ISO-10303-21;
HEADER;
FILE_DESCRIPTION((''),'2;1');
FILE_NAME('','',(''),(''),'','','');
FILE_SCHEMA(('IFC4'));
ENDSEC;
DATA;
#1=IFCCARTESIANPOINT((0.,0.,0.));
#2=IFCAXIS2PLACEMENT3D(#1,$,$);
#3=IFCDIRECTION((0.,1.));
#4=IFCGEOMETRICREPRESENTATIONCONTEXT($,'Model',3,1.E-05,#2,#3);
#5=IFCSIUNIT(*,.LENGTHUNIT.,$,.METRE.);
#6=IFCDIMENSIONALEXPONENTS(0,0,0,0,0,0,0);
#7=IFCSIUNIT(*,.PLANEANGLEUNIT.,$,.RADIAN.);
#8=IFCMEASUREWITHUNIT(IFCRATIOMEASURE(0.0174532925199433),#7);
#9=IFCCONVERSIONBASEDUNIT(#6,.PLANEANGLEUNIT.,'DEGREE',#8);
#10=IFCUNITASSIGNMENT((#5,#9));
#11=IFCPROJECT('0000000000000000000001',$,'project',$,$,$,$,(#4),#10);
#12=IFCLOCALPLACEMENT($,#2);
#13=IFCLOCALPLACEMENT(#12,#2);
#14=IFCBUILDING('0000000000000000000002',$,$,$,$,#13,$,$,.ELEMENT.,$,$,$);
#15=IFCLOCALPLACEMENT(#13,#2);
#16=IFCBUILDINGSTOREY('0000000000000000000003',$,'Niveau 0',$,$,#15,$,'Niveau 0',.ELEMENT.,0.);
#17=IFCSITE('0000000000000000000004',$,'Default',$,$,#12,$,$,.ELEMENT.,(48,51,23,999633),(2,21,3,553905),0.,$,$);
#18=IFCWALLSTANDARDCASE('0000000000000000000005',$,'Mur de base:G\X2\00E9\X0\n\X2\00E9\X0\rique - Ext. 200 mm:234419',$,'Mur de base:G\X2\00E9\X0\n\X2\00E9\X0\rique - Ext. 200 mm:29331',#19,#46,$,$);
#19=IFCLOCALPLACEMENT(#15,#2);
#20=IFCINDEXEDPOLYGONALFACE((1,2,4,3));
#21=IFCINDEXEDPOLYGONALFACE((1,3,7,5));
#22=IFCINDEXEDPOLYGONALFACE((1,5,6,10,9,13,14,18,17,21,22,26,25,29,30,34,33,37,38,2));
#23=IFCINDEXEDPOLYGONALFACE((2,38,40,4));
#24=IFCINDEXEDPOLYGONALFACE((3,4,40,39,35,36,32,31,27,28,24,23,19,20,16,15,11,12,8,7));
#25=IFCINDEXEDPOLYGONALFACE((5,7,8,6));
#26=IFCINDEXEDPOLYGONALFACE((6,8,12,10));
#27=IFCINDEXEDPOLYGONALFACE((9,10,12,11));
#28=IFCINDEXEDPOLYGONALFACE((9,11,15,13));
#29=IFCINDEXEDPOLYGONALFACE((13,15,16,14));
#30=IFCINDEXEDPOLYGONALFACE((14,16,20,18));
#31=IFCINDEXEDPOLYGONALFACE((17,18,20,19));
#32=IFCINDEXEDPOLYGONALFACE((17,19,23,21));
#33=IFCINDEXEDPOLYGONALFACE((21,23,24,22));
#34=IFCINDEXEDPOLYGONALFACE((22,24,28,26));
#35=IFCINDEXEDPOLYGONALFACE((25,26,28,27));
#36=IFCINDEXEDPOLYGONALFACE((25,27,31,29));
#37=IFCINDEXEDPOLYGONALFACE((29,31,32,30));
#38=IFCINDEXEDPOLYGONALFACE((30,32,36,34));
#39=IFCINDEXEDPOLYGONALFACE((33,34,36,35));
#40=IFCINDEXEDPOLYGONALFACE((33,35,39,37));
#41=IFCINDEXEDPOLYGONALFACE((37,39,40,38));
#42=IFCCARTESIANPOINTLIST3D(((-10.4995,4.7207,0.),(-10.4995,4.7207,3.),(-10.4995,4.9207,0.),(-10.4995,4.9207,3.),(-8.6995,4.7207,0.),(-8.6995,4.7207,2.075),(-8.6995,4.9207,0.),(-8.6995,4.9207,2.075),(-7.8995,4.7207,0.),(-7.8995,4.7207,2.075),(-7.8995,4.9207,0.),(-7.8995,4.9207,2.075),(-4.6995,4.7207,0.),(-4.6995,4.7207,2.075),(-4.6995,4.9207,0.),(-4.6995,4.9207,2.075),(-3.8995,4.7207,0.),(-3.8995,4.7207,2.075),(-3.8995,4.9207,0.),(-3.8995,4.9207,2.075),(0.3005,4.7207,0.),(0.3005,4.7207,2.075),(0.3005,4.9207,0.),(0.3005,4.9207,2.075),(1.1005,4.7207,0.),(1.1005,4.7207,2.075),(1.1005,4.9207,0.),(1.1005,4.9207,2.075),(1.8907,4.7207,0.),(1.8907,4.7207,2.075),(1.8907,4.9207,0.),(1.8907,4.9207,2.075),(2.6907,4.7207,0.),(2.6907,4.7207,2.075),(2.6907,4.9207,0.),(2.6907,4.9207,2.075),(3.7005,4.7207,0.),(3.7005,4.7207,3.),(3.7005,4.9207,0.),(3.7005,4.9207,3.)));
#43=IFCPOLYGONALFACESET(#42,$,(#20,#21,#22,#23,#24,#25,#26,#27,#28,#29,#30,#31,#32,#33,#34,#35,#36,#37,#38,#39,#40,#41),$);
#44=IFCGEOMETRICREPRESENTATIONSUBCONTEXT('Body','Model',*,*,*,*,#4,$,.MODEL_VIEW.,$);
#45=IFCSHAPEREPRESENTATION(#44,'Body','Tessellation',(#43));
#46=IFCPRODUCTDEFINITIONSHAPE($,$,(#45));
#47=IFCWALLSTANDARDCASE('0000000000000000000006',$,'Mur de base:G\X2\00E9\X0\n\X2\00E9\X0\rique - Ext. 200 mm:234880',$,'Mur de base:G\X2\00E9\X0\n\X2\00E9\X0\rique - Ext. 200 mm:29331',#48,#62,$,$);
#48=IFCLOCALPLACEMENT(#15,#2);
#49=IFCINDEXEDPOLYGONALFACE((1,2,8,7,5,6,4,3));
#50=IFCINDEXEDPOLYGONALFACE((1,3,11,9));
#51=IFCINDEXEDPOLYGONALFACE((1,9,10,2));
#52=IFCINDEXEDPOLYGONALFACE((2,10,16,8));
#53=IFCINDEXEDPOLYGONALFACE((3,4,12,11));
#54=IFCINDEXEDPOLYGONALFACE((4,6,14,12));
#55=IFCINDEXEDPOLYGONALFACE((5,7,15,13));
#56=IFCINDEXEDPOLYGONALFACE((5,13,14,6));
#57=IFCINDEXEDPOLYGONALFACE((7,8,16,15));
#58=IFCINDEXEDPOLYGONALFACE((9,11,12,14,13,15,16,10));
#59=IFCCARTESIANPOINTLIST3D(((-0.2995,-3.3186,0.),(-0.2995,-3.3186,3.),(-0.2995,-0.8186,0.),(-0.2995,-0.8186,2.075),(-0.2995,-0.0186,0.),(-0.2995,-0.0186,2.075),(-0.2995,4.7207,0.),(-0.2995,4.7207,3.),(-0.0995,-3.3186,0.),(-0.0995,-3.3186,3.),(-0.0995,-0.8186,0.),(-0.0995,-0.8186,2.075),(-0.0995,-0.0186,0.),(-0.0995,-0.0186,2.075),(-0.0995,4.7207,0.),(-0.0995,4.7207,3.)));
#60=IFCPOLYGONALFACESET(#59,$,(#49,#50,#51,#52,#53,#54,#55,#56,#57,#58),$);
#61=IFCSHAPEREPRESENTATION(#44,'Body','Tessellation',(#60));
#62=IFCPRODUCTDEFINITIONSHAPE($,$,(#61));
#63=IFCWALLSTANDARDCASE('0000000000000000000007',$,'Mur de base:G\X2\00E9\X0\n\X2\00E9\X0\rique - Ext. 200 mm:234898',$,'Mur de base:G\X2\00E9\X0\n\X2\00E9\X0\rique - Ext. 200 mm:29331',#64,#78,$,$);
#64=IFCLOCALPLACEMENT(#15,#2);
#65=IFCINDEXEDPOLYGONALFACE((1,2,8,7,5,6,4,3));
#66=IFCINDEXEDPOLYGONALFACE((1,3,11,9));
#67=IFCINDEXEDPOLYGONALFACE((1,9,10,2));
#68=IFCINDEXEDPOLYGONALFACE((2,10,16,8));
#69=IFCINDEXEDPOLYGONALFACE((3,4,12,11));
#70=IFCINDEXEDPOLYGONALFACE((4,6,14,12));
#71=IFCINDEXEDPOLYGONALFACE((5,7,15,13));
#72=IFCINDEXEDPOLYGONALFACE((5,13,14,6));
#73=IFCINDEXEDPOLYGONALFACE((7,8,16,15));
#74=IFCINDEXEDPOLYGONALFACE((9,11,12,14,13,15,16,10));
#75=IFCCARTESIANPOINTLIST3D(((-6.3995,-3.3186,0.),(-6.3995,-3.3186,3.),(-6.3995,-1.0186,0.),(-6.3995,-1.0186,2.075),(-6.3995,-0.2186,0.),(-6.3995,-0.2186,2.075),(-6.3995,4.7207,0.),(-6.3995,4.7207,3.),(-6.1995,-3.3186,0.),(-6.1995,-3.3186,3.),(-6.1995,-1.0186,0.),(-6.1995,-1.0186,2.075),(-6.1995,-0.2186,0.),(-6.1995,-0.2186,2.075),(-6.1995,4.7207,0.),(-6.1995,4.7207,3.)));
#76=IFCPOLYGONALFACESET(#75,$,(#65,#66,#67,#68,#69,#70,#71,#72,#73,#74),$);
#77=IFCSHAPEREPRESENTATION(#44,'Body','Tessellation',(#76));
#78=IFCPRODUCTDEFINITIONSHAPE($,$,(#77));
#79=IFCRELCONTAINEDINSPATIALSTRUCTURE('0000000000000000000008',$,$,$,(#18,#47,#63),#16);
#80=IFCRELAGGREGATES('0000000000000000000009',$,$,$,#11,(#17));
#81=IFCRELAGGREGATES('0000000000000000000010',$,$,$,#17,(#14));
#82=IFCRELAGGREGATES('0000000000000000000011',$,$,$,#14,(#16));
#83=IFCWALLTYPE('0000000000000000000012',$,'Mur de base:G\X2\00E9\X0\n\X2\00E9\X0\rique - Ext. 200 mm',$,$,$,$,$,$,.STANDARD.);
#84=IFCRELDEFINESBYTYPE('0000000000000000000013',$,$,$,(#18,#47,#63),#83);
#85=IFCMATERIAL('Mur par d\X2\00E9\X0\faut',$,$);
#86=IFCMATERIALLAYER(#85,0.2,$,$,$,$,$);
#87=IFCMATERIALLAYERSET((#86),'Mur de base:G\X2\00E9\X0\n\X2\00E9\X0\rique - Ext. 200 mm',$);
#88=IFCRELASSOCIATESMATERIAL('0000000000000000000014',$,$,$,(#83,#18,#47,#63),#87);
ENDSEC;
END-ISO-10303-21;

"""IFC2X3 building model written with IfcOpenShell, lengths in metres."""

from ifc_helpers import new_model, entity, si_unit, converted_unit, direction, frame, frame_2d, origin, place, context, subcontext, project, spatial, rectangle, extrude, material, layer, layer_set, layer_usage, type_object, element, save


model = new_model("IFC2X3")

# Units and contexts
model_context = context("Model", 3, precision=1e-05, world=origin(), true_north=direction((0.0, 1.0)))
body_context = subcontext(model_context, "Body", "Model", "MODEL_VIEW")
ifc_project = project(units=[si_unit("LENGTHUNIT", "METRE"), converted_unit("PLANEANGLEUNIT", "DEGREE", entity("IfcRatioMeasure", 0.0174532925199433), si_unit("PLANEANGLEUNIT", "RADIAN"), dimensions=[0, 0, 0, 0, 0, 0, 0])], contexts=[model_context])

# Site, building, storey
site_placement = place(None, origin())
site = spatial("IfcSite", under=ifc_project, at=site_placement, Name="Default", CompositionType="ELEMENT", RefLatitude=(48, 51, 23, 999633), RefLongitude=(2, 21, 3, 553905), RefElevation=0.0)
building_placement = place(site_placement, origin())
building = spatial("IfcBuilding", under=site, at=building_placement, CompositionType="ELEMENT")
storey_placement = place(building_placement, origin())
storey = spatial("IfcBuildingStorey", under=building, at=storey_placement, Name="Niveau 0", LongName="Niveau 0", CompositionType="ELEMENT", Elevation=0.0)

# Wall, openings
ifc_material = material(Name="Mur par défaut")
ifc_layer = layer(ifc_material, 0.2)
ifc_layer_set = layer_set([ifc_layer], Name="Mur de base:Générique - Ext. 200 mm")
ifc_layer_usage_1 = layer_usage(ifc_layer_set, "AXIS2", "NEGATIVE", 0.1)
wall_type = type_object("IfcWallType", Name="Mur de base:Générique - Ext. 200 mm", PredefinedType="STANDARD", material=ifc_layer_set)
wall_1_placement = place(storey_placement, frame((-10.4995, 4.8207, 0.0)))
wall_1 = element("IfcWallStandardCase", 1, at=wall_1_placement, inside=storey, type_object=wall_type, material=ifc_layer_usage_1, Name="Mur de base:Générique - Ext. 200 mm:234419", ObjectType="Mur de base:Générique - Ext. 200 mm:29331", context=body_context, shape_type="SweptSolid", body=[
    extrude(rectangle(XDim=14.2, YDim=0.2, at=frame_2d((7.1, 0.0), x_axis=(-1.0, 0.0))), origin(), (0.0, 0.0, 1.0), 3.0),
])
opening_1_placement = place(wall_1_placement, frame((2.6, 0.1, 0.0)))
element("IfcOpeningElement", 2, at=opening_1_placement, cuts=wall_1, ObjectType="Opening", context=body_context, shape_type="SweptSolid", body=[
    extrude(rectangle(XDim=2.075, YDim=0.8, at=frame_2d((1.0375, 0.4), x_axis=(1.0, 0.0))), frame((0.0, 0.0, 0.0), z_axis=(0.0, -1.0, 0.0), x_axis=(0.0, 0.0, 1.0)), (0.0, 0.0, 1.0), 0.2),
])
opening_2_placement = place(wall_1_placement, frame((6.6, 0.1, 0.0)))
element("IfcOpeningElement", 3, at=opening_2_placement, cuts=wall_1, ObjectType="Opening", context=body_context, shape_type="SweptSolid", body=[
    extrude(rectangle(XDim=2.075, YDim=0.8, at=frame_2d((1.0375, 0.4), x_axis=(1.0, 0.0))), frame((0.0, 0.0, 0.0), z_axis=(0.0, -1.0, 0.0), x_axis=(0.0, 0.0, 1.0)), (0.0, 0.0, 1.0), 0.2),
])
opening_3_placement = place(wall_1_placement, frame((10.8, -0.1, 0.0)))
element("IfcOpeningElement", 4, at=opening_3_placement, cuts=wall_1, ObjectType="Opening", context=body_context, shape_type="SweptSolid", body=[
    extrude(rectangle(XDim=2.075, YDim=0.8, at=frame_2d((1.0375, 0.4), x_axis=(1.0, 0.0))), frame((0.0, 0.0, 0.0), z_axis=(0.0, 1.0, 0.0), x_axis=(0.0, 0.0, 1.0)), (0.0, 0.0, 1.0), 0.2),
])
opening_4_placement = place(wall_1_placement, frame((12.3903, -0.1, 0.0)))
element("IfcOpeningElement", 5, at=opening_4_placement, cuts=wall_1, ObjectType="Opening", context=body_context, shape_type="SweptSolid", body=[
    extrude(rectangle(XDim=2.075, YDim=0.8, at=frame_2d((1.0375, 0.4), x_axis=(1.0, 0.0))), frame((0.0, 0.0, 0.0), z_axis=(0.0, 1.0, 0.0), x_axis=(0.0, 0.0, 1.0)), (0.0, 0.0, 1.0), 0.2),
])

# Walls, openings
ifc_layer_usage_2 = layer_usage(ifc_layer_set, "AXIS2", "NEGATIVE", 0.1)
wall_2_placement = place(storey_placement, frame((-0.1995, 4.7207, 0.0), z_axis=(0.0, 0.0, 1.0), x_axis=(0.0, -1.0, 0.0)))
wall_2 = element("IfcWallStandardCase", 6, at=wall_2_placement, inside=storey, type_object=wall_type, material=ifc_layer_usage_2, Name="Mur de base:Générique - Ext. 200 mm:234880", ObjectType="Mur de base:Générique - Ext. 200 mm:29331", context=body_context, shape_type="SweptSolid", body=[
    extrude(rectangle(XDim=8.0393, YDim=0.2, at=frame_2d((4.0196, 0.0), x_axis=(-1.0, 0.0))), origin(), (0.0, 0.0, 1.0), 3.0),
])
opening_5_placement = place(wall_2_placement, frame((5.5393, 0.1, 0.0)))
element("IfcOpeningElement", 7, at=opening_5_placement, cuts=wall_2, ObjectType="Opening", context=body_context, shape_type="SweptSolid", body=[
    extrude(rectangle(XDim=2.075, YDim=0.8, at=frame_2d((1.0375, 0.4), x_axis=(1.0, 0.0))), frame((0.0, 0.0, 0.0), z_axis=(0.0, -1.0, 0.0), x_axis=(0.0, 0.0, 1.0)), (0.0, 0.0, 1.0), 0.2),
])
ifc_layer_usage_3 = layer_usage(ifc_layer_set, "AXIS2", "NEGATIVE", 0.1)
wall_3_placement = place(storey_placement, frame((-6.2995, 4.7207, 0.0), z_axis=(0.0, 0.0, 1.0), x_axis=(0.0, -1.0, 0.0)))
wall_3 = element("IfcWallStandardCase", 8, at=wall_3_placement, inside=storey, type_object=wall_type, material=ifc_layer_usage_3, Name="Mur de base:Générique - Ext. 200 mm:234898", ObjectType="Mur de base:Générique - Ext. 200 mm:29331", context=body_context, shape_type="SweptSolid", body=[
    extrude(rectangle(XDim=8.0393, YDim=0.2, at=frame_2d((4.0196, 0.0), x_axis=(-1.0, 0.0))), origin(), (0.0, 0.0, 1.0), 3.0),
])
opening_6_placement = place(wall_3_placement, frame((4.9393, -0.1, 0.0)))
element("IfcOpeningElement", 9, at=opening_6_placement, cuts=wall_3, ObjectType="Opening", context=body_context, shape_type="SweptSolid", body=[
    extrude(rectangle(XDim=2.075, YDim=0.8, at=frame_2d((1.0375, 0.4), x_axis=(1.0, 0.0))), frame((0.0, 0.0, 0.0), z_axis=(0.0, 1.0, 0.0), x_axis=(0.0, 0.0, 1.0)), (0.0, 0.0, 1.0), 0.2),
])

save(model, "model.ifc")
